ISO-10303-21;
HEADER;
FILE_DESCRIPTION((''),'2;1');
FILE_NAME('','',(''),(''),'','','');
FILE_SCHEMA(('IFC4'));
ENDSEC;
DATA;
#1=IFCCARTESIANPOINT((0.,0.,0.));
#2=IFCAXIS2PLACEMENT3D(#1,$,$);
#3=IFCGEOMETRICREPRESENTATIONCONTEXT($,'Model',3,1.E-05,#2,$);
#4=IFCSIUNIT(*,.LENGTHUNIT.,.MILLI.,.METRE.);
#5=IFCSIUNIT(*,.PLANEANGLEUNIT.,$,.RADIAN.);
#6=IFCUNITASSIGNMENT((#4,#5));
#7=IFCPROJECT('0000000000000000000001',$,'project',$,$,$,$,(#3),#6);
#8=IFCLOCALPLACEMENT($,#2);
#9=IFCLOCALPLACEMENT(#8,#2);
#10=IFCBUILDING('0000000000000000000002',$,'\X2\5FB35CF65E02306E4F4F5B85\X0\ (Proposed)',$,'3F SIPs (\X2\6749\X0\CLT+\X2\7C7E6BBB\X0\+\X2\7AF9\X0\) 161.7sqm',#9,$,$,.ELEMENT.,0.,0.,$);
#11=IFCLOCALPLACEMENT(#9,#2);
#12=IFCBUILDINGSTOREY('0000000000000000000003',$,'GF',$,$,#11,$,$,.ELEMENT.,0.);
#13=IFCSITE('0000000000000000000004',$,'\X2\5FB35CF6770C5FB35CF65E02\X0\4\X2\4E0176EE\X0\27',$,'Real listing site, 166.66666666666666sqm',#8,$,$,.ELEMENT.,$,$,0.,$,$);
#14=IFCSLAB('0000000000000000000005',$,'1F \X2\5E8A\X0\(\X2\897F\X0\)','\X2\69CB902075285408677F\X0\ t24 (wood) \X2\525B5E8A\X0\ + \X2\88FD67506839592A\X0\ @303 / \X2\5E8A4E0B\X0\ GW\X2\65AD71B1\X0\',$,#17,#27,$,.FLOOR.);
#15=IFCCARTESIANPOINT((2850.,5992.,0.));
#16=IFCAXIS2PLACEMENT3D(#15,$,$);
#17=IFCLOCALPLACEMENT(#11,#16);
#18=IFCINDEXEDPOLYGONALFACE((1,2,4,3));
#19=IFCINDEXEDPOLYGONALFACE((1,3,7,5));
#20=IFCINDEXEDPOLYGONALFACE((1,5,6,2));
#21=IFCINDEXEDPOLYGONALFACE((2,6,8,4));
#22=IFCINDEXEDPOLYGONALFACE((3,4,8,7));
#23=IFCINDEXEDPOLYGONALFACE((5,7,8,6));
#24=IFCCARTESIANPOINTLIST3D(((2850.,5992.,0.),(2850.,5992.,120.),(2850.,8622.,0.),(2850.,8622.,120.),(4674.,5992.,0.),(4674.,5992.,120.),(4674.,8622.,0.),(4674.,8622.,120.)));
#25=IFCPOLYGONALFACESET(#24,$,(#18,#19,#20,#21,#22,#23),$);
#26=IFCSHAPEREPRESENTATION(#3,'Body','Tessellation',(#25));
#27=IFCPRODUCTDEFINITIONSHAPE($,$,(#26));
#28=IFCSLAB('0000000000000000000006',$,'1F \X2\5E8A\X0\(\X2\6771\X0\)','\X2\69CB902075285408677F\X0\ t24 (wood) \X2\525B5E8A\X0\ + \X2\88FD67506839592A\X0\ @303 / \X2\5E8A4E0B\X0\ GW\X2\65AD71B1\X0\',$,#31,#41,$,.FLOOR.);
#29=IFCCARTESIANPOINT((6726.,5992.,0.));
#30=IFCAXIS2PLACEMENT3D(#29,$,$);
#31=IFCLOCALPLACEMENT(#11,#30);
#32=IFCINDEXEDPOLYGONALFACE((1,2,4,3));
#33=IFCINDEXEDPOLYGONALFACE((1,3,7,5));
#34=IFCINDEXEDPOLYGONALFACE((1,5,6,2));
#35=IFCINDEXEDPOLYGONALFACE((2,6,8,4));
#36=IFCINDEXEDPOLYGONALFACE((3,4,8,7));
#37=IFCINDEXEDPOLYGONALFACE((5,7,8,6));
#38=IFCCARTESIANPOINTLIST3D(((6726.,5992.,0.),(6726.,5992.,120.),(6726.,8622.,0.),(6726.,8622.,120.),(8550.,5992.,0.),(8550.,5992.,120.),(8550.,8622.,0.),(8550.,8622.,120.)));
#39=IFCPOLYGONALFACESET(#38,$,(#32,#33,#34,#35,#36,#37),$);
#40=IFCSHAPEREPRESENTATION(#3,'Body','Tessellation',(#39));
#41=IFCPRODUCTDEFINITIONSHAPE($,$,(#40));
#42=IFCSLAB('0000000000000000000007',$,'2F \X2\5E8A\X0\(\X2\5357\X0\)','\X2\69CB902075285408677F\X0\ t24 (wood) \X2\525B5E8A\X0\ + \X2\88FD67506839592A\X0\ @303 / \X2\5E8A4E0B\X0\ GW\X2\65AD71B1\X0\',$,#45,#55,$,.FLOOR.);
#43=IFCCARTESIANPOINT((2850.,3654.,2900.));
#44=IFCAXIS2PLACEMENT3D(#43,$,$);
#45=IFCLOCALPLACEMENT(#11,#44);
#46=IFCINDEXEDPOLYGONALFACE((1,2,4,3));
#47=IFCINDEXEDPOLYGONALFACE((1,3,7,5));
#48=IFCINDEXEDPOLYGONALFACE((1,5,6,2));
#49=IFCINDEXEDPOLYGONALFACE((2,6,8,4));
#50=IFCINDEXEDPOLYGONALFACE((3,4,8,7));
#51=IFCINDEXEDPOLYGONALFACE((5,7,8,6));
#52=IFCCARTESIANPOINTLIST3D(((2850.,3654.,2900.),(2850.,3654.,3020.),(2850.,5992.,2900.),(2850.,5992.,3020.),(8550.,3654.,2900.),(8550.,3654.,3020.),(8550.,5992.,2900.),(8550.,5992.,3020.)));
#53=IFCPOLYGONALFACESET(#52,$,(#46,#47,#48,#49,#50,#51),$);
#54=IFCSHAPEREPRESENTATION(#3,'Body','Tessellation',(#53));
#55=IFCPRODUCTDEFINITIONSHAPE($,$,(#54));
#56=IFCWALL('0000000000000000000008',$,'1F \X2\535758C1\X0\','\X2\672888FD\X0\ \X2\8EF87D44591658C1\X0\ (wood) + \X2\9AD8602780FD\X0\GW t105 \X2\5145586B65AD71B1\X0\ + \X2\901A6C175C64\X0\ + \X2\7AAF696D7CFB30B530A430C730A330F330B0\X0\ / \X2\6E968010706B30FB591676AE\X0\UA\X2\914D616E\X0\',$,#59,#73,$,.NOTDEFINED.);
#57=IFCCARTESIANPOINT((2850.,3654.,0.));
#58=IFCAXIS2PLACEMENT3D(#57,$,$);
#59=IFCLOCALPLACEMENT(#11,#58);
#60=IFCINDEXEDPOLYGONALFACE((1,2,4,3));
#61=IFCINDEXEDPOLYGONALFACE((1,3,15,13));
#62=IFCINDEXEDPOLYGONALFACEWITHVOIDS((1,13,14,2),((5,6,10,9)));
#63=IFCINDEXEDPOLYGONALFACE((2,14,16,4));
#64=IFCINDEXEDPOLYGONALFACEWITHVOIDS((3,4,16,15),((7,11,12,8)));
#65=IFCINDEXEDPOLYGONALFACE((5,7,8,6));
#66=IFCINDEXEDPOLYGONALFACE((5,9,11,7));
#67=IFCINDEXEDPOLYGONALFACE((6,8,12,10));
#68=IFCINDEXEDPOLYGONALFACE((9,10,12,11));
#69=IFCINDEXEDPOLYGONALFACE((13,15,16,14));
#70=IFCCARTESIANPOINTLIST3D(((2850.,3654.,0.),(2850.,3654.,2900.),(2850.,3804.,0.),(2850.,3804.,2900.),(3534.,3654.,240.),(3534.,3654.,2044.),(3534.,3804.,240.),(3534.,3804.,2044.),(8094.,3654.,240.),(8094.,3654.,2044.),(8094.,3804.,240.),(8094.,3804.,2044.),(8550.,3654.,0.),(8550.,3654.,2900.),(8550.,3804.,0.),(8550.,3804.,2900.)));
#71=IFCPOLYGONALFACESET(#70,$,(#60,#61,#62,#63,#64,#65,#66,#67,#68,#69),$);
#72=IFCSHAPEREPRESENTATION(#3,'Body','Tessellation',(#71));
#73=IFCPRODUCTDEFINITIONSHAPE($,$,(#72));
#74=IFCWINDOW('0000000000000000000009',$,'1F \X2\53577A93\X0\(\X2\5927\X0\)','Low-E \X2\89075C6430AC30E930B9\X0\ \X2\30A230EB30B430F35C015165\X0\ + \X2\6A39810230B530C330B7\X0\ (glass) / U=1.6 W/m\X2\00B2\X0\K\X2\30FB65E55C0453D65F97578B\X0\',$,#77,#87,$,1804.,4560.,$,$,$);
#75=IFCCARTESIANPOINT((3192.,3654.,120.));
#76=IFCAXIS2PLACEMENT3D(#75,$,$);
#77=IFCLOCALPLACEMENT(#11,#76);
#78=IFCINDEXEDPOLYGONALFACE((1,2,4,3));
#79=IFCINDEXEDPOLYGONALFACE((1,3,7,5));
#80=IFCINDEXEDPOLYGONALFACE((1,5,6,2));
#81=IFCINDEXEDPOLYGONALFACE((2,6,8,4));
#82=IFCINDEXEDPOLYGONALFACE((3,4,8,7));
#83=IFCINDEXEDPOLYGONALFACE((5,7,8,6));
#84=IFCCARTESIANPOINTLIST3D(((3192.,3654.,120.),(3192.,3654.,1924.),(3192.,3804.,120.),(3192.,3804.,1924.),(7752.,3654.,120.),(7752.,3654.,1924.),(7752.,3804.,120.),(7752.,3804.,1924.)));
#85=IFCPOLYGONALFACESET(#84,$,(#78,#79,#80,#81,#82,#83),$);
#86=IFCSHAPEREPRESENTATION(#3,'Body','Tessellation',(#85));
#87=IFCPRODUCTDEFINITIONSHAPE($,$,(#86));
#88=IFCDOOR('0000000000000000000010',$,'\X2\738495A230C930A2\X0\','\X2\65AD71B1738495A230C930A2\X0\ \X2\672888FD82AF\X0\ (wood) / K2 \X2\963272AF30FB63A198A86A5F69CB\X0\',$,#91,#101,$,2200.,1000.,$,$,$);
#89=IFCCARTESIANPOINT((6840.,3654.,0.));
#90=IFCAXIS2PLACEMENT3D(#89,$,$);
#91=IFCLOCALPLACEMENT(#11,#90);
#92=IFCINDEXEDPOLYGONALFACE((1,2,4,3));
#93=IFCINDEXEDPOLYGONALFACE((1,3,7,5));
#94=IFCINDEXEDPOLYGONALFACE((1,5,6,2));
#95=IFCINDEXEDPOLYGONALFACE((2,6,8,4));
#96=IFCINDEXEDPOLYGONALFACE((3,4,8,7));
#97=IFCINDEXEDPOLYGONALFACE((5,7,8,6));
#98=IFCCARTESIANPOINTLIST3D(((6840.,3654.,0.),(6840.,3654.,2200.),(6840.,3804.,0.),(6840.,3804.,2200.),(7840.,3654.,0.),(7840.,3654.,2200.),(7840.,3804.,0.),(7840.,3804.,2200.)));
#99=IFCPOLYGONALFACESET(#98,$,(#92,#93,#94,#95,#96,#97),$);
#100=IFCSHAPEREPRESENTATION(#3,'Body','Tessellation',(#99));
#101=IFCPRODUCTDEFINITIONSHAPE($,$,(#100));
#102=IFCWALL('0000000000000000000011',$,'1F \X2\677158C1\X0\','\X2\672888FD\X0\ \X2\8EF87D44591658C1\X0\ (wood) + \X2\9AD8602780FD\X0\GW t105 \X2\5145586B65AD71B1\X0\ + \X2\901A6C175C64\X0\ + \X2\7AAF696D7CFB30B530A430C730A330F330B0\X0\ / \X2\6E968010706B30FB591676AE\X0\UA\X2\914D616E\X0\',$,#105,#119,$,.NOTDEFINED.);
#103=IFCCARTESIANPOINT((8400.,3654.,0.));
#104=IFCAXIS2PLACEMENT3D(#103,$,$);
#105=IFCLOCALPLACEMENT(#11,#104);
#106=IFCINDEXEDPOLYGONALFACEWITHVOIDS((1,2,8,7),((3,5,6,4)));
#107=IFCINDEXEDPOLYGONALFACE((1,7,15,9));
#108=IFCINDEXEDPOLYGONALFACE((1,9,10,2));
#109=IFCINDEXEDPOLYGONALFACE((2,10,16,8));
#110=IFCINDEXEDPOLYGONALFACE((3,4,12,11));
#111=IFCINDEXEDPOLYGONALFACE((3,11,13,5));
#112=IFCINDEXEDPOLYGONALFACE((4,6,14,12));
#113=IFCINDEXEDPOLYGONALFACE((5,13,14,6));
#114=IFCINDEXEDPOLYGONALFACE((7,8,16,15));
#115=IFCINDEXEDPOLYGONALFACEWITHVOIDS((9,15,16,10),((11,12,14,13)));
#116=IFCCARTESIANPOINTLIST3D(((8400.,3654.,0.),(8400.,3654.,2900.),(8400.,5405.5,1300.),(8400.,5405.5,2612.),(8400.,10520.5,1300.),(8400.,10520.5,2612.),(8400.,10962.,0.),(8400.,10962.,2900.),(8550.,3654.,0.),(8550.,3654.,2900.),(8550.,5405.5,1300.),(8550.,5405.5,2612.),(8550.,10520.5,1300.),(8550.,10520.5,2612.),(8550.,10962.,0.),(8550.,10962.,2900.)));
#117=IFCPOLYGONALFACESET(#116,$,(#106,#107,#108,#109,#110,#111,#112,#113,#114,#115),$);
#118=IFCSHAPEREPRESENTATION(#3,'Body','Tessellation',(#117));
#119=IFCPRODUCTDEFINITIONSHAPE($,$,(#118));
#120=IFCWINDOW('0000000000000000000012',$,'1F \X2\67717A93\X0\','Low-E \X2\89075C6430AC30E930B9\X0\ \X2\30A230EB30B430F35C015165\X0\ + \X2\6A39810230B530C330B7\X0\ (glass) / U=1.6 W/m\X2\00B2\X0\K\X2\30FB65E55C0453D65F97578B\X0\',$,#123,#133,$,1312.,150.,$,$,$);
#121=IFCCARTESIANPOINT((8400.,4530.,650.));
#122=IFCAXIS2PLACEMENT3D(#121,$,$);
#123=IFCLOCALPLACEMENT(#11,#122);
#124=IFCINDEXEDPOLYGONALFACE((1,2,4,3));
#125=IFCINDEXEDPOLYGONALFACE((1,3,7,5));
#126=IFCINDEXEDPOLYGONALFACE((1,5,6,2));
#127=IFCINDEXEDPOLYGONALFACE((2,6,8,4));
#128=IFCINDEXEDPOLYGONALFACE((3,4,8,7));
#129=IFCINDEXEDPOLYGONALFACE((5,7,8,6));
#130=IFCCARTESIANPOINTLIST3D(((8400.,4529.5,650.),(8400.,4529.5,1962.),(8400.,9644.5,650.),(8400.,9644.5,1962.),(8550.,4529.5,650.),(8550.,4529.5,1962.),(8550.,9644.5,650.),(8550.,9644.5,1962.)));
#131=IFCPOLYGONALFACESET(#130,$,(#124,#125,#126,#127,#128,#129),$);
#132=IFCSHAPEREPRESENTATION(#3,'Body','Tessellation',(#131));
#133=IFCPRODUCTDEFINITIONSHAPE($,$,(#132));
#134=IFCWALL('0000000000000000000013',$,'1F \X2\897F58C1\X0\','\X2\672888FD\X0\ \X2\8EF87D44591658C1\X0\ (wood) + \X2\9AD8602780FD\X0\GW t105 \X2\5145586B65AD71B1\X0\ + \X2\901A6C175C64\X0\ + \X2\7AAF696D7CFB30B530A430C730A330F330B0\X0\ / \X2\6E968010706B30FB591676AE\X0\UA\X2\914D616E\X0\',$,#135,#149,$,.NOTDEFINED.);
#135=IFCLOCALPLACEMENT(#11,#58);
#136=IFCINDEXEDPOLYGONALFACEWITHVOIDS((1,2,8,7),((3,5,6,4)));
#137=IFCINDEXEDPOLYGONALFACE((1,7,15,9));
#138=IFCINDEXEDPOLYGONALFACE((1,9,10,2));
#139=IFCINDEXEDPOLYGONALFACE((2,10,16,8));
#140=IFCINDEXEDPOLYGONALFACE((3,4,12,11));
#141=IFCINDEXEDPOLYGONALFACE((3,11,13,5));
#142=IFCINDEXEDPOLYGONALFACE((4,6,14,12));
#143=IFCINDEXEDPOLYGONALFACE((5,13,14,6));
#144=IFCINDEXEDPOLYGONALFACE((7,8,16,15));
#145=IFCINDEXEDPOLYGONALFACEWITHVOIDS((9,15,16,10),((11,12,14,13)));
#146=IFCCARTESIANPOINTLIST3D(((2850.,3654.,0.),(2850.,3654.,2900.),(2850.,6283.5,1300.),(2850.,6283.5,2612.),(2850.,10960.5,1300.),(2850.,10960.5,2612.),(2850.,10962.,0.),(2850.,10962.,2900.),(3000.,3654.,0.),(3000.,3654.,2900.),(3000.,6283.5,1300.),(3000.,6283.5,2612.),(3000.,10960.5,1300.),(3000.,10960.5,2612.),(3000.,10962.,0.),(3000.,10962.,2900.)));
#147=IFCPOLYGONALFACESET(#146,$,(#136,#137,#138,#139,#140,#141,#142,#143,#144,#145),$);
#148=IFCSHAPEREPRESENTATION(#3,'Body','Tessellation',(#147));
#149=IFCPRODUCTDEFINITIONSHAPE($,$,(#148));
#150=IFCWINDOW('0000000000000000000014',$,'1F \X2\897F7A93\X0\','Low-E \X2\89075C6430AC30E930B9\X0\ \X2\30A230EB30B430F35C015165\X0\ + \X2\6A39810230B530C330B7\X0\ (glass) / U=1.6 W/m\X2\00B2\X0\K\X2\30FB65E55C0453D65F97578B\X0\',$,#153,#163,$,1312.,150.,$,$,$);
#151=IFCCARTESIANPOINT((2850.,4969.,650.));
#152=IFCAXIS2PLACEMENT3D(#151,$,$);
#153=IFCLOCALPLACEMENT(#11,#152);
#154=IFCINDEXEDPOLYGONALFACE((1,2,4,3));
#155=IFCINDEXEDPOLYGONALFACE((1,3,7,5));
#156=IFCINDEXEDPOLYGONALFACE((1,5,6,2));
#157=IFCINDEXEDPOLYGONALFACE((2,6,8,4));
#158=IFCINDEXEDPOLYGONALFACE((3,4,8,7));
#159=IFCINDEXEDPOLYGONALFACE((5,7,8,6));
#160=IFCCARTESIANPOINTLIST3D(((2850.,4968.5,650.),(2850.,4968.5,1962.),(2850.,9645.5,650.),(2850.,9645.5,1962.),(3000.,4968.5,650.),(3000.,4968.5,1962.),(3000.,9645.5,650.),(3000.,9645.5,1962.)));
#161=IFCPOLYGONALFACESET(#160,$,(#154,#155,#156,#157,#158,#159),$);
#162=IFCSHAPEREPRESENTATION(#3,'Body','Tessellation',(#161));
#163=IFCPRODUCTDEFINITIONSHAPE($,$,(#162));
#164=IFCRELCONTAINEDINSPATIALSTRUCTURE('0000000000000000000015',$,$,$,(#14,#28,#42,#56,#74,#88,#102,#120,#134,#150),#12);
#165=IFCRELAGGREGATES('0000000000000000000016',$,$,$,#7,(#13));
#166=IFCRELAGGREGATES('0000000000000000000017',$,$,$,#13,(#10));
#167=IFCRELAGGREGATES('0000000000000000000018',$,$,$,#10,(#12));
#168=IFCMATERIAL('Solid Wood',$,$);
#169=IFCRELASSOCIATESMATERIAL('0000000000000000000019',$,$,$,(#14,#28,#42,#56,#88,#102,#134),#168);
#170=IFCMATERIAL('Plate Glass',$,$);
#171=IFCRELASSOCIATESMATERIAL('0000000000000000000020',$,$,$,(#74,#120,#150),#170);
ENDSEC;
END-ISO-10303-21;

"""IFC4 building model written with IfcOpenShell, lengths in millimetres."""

from ifc_helpers import new_model, si_unit, frame, frame_2d, origin, place, context, project, spatial, rectangle, extrude, material, element, fill, save


model = new_model("IFC4")

# Units and contexts
model_context = context("Model", 3, precision=1e-05, world=origin())
ifc_project = project(units=[si_unit("LENGTHUNIT", "METRE", prefix="MILLI"), si_unit("PLANEANGLEUNIT", "RADIAN")], contexts=[model_context])

# Site, building, storey
site_placement = place(None, origin())
site = spatial("IfcSite", under=ifc_project, at=site_placement, Name="徳島県徳島市4丁目27", ObjectType="Real listing site, 166.66666666666666sqm", CompositionType="ELEMENT", RefElevation=0.0)
building_placement = place(site_placement, origin())
building = spatial("IfcBuilding", under=site, at=building_placement, Name="徳島市の住宅 (Proposed)", ObjectType="3F SIPs (杉CLT+籾殻+竹) 161.7sqm", CompositionType="ELEMENT", ElevationOfRefHeight=0.0, ElevationOfTerrain=0.0)
storey_placement = place(building_placement, origin())
storey = spatial("IfcBuildingStorey", under=building, at=storey_placement, Name="GF", CompositionType="ELEMENT", Elevation=0.0)

# Slabs
ifc_material_1 = material(Name="Solid Wood")
slab_1_placement = place(storey_placement, frame((2850.0, 5992.0, 0.0)))
element("IfcSlab", 1, at=slab_1_placement, inside=storey, material=ifc_material_1, Name="1F 床(西)", Description="構造用合板 t24 (wood) 剛床 + 製材根太 @303 / 床下 GW断熱", PredefinedType="FLOOR", context=model_context, shape_type="SweptSolid", body=[
    extrude(rectangle(XDim=1824.0, YDim=2630.0, at=frame_2d((912.0, 1315.0))), frame((2850.0, 5992.0, 0.0)), (0.0, 0.0, 1.0), 120.0),
])
slab_2_placement = place(storey_placement, frame((6726.0, 5992.0, 0.0)))
element("IfcSlab", 2, at=slab_2_placement, inside=storey, material=ifc_material_1, Name="1F 床(東)", Description="構造用合板 t24 (wood) 剛床 + 製材根太 @303 / 床下 GW断熱", PredefinedType="FLOOR", context=model_context, shape_type="SweptSolid", body=[
    extrude(rectangle(XDim=1824.0, YDim=2630.0, at=frame_2d((912.0, 1315.0))), frame((6726.0, 5992.0, 0.0)), (0.0, 0.0, 1.0), 120.0),
])
slab_3_placement = place(storey_placement, frame((2850.0, 3654.0, 2900.0)))
element("IfcSlab", 3, at=slab_3_placement, inside=storey, material=ifc_material_1, Name="2F 床(南)", Description="構造用合板 t24 (wood) 剛床 + 製材根太 @303 / 床下 GW断熱", PredefinedType="FLOOR", context=model_context, shape_type="SweptSolid", body=[
    extrude(rectangle(XDim=5700.0, YDim=2338.0, at=frame_2d((2850.0, 1169.0))), frame((2850.0, 3654.0, 2900.0)), (0.0, 0.0, 1.0), 120.0),
])

# Wall, openings, window, door
wall_1_placement = place(storey_placement, frame((2850.0, 3654.0, 0.0)))
wall_1 = element("IfcWall", 4, at=wall_1_placement, inside=storey, material=ifc_material_1, Name="1F 南壁", Description="木製 軸組外壁 (wood) + 高性能GW t105 充填断熱 + 通気層 + 窯業系サイディング / 準耐火・外皮UA配慮", PredefinedType="NOTDEFINED", context=model_context, shape_type="SweptSolid", body=[
    extrude(rectangle(XDim=5700.0, YDim=150.0, at=frame_2d((2850.0, 75.0))), frame((2850.0, 3654.0, 0.0)), (0.0, 0.0, 1.0), 2900.0),
])
opening_1_placement = place(storey_placement, frame((3192.0, 3654.0, 120.0)))
opening_1 = element("IfcOpeningElement", 5, at=opening_1_placement, cuts=wall_1, PredefinedType="NOTDEFINED", context=model_context, shape_type="SweptSolid", body=[
    extrude(rectangle(XDim=4560.0, YDim=150.0, at=frame_2d((2280.0, 75.0))), frame((3192.0, 3654.0, 120.0)), (0.0, 0.0, 1.0), 1804.0),
])
opening_2_placement = place(storey_placement, frame((6840.0, 3654.0, 0.0)))
opening_2 = element("IfcOpeningElement", 6, at=opening_2_placement, cuts=wall_1, PredefinedType="NOTDEFINED", context=model_context, shape_type="SweptSolid", body=[
    extrude(rectangle(XDim=1000.0, YDim=150.0, at=frame_2d((500.0, 75.0))), frame((6840.0, 3654.0, 0.0)), (0.0, 0.0, 1.0), 2200.0),
])
ifc_material_2 = material(Name="Plate Glass")
window_1_placement = place(storey_placement, frame((3192.0, 3654.0, 120.0)))
window_1 = element("IfcWindow", 7, at=window_1_placement, inside=storey, material=ifc_material_2, Name="1F 南窓(大)", Description="Low-E 複層ガラス アルゴン封入 + 樹脂サッシ (glass) / U=1.6 W/m²K・日射取得型", OverallHeight=1804.0, OverallWidth=4560.0, context=model_context, shape_type="SweptSolid", body=[
    extrude(rectangle(XDim=4560.0, YDim=150.0, at=frame_2d((2280.0, 75.0))), frame((3192.0, 3654.0, 120.0)), (0.0, 0.0, 1.0), 1804.0),
])
fill(opening_1, window_1)
door_placement = place(storey_placement, frame((6840.0, 3654.0, 0.0)))
door = element("IfcDoor", 8, at=door_placement, inside=storey, material=ifc_material_1, Name="玄関ドア", Description="断熱玄関ドア 木製芯 (wood) / K2 防犯・採風機構", OverallHeight=2200.0, OverallWidth=1000.0, context=model_context, shape_type="SweptSolid", body=[
    extrude(rectangle(XDim=1000.0, YDim=150.0, at=frame_2d((500.0, 75.0))), frame((6840.0, 3654.0, 0.0)), (0.0, 0.0, 1.0), 2200.0),
])
fill(opening_2, door)

# Walls, openings, windows
wall_2_placement = place(storey_placement, frame((8400.0, 3654.0, 0.0)))
wall_2 = element("IfcWall", 9, at=wall_2_placement, inside=storey, material=ifc_material_1, Name="1F 東壁", Description="木製 軸組外壁 (wood) + 高性能GW t105 充填断熱 + 通気層 + 窯業系サイディング / 準耐火・外皮UA配慮", PredefinedType="NOTDEFINED", context=model_context, shape_type="SweptSolid", body=[
    extrude(rectangle(XDim=150.0, YDim=7308.0, at=frame_2d((75.0, 3654.0))), frame((8400.0, 3654.0, 0.0)), (0.0, 0.0, 1.0), 2900.0),
])
opening_3_placement = place(storey_placement, frame((8400.0, 4530.0, 650.0)))
opening_3 = element("IfcOpeningElement", 10, at=opening_3_placement, cuts=wall_2, PredefinedType="NOTDEFINED", context=model_context, shape_type="SweptSolid", body=[
    extrude(rectangle(XDim=150.0, YDim=5115.0, at=frame_2d((75.0, 2557.0))), frame((8400.0, 4530.0, 650.0)), (0.0, 0.0, 1.0), 1312.0),
])
window_2_placement = place(storey_placement, frame((8400.0, 4530.0, 650.0)))
window_2 = element("IfcWindow", 11, at=window_2_placement, inside=storey, material=ifc_material_2, Name="1F 東窓", Description="Low-E 複層ガラス アルゴン封入 + 樹脂サッシ (glass) / U=1.6 W/m²K・日射取得型", OverallHeight=1312.0, OverallWidth=150.0, context=model_context, shape_type="SweptSolid", body=[
    extrude(rectangle(XDim=150.0, YDim=5115.0, at=frame_2d((75.0, 2557.0))), frame((8400.0, 4530.0, 650.0)), (0.0, 0.0, 1.0), 1312.0),
])
fill(opening_3, window_2)
wall_3_placement = place(storey_placement, frame((2850.0, 3654.0, 0.0)))
wall_3 = element("IfcWall", 12, at=wall_3_placement, inside=storey, material=ifc_material_1, Name="1F 西壁", Description="木製 軸組外壁 (wood) + 高性能GW t105 充填断熱 + 通気層 + 窯業系サイディング / 準耐火・外皮UA配慮", PredefinedType="NOTDEFINED", context=model_context, shape_type="SweptSolid", body=[
    extrude(rectangle(XDim=150.0, YDim=7308.0, at=frame_2d((75.0, 3654.0))), frame((2850.0, 3654.0, 0.0)), (0.0, 0.0, 1.0), 2900.0),
])
opening_4_placement = place(storey_placement, frame((2850.0, 4969.0, 650.0)))
opening_4 = element("IfcOpeningElement", 13, at=opening_4_placement, cuts=wall_3, PredefinedType="NOTDEFINED", context=model_context, shape_type="SweptSolid", body=[
    extrude(rectangle(XDim=150.0, YDim=4677.0, at=frame_2d((75.0, 2338.0))), frame((2850.0, 4969.0, 650.0)), (0.0, 0.0, 1.0), 1312.0),
])
window_3_placement = place(storey_placement, frame((2850.0, 4969.0, 650.0)))
window_3 = element("IfcWindow", 14, at=window_3_placement, inside=storey, material=ifc_material_2, Name="1F 西窓", Description="Low-E 複層ガラス アルゴン封入 + 樹脂サッシ (glass) / U=1.6 W/m²K・日射取得型", OverallHeight=1312.0, OverallWidth=150.0, context=model_context, shape_type="SweptSolid", body=[
    extrude(rectangle(XDim=150.0, YDim=4677.0, at=frame_2d((75.0, 2338.0))), frame((2850.0, 4969.0, 650.0)), (0.0, 0.0, 1.0), 1312.0),
])
fill(opening_4, window_3)

save(model, "model.ifc")
